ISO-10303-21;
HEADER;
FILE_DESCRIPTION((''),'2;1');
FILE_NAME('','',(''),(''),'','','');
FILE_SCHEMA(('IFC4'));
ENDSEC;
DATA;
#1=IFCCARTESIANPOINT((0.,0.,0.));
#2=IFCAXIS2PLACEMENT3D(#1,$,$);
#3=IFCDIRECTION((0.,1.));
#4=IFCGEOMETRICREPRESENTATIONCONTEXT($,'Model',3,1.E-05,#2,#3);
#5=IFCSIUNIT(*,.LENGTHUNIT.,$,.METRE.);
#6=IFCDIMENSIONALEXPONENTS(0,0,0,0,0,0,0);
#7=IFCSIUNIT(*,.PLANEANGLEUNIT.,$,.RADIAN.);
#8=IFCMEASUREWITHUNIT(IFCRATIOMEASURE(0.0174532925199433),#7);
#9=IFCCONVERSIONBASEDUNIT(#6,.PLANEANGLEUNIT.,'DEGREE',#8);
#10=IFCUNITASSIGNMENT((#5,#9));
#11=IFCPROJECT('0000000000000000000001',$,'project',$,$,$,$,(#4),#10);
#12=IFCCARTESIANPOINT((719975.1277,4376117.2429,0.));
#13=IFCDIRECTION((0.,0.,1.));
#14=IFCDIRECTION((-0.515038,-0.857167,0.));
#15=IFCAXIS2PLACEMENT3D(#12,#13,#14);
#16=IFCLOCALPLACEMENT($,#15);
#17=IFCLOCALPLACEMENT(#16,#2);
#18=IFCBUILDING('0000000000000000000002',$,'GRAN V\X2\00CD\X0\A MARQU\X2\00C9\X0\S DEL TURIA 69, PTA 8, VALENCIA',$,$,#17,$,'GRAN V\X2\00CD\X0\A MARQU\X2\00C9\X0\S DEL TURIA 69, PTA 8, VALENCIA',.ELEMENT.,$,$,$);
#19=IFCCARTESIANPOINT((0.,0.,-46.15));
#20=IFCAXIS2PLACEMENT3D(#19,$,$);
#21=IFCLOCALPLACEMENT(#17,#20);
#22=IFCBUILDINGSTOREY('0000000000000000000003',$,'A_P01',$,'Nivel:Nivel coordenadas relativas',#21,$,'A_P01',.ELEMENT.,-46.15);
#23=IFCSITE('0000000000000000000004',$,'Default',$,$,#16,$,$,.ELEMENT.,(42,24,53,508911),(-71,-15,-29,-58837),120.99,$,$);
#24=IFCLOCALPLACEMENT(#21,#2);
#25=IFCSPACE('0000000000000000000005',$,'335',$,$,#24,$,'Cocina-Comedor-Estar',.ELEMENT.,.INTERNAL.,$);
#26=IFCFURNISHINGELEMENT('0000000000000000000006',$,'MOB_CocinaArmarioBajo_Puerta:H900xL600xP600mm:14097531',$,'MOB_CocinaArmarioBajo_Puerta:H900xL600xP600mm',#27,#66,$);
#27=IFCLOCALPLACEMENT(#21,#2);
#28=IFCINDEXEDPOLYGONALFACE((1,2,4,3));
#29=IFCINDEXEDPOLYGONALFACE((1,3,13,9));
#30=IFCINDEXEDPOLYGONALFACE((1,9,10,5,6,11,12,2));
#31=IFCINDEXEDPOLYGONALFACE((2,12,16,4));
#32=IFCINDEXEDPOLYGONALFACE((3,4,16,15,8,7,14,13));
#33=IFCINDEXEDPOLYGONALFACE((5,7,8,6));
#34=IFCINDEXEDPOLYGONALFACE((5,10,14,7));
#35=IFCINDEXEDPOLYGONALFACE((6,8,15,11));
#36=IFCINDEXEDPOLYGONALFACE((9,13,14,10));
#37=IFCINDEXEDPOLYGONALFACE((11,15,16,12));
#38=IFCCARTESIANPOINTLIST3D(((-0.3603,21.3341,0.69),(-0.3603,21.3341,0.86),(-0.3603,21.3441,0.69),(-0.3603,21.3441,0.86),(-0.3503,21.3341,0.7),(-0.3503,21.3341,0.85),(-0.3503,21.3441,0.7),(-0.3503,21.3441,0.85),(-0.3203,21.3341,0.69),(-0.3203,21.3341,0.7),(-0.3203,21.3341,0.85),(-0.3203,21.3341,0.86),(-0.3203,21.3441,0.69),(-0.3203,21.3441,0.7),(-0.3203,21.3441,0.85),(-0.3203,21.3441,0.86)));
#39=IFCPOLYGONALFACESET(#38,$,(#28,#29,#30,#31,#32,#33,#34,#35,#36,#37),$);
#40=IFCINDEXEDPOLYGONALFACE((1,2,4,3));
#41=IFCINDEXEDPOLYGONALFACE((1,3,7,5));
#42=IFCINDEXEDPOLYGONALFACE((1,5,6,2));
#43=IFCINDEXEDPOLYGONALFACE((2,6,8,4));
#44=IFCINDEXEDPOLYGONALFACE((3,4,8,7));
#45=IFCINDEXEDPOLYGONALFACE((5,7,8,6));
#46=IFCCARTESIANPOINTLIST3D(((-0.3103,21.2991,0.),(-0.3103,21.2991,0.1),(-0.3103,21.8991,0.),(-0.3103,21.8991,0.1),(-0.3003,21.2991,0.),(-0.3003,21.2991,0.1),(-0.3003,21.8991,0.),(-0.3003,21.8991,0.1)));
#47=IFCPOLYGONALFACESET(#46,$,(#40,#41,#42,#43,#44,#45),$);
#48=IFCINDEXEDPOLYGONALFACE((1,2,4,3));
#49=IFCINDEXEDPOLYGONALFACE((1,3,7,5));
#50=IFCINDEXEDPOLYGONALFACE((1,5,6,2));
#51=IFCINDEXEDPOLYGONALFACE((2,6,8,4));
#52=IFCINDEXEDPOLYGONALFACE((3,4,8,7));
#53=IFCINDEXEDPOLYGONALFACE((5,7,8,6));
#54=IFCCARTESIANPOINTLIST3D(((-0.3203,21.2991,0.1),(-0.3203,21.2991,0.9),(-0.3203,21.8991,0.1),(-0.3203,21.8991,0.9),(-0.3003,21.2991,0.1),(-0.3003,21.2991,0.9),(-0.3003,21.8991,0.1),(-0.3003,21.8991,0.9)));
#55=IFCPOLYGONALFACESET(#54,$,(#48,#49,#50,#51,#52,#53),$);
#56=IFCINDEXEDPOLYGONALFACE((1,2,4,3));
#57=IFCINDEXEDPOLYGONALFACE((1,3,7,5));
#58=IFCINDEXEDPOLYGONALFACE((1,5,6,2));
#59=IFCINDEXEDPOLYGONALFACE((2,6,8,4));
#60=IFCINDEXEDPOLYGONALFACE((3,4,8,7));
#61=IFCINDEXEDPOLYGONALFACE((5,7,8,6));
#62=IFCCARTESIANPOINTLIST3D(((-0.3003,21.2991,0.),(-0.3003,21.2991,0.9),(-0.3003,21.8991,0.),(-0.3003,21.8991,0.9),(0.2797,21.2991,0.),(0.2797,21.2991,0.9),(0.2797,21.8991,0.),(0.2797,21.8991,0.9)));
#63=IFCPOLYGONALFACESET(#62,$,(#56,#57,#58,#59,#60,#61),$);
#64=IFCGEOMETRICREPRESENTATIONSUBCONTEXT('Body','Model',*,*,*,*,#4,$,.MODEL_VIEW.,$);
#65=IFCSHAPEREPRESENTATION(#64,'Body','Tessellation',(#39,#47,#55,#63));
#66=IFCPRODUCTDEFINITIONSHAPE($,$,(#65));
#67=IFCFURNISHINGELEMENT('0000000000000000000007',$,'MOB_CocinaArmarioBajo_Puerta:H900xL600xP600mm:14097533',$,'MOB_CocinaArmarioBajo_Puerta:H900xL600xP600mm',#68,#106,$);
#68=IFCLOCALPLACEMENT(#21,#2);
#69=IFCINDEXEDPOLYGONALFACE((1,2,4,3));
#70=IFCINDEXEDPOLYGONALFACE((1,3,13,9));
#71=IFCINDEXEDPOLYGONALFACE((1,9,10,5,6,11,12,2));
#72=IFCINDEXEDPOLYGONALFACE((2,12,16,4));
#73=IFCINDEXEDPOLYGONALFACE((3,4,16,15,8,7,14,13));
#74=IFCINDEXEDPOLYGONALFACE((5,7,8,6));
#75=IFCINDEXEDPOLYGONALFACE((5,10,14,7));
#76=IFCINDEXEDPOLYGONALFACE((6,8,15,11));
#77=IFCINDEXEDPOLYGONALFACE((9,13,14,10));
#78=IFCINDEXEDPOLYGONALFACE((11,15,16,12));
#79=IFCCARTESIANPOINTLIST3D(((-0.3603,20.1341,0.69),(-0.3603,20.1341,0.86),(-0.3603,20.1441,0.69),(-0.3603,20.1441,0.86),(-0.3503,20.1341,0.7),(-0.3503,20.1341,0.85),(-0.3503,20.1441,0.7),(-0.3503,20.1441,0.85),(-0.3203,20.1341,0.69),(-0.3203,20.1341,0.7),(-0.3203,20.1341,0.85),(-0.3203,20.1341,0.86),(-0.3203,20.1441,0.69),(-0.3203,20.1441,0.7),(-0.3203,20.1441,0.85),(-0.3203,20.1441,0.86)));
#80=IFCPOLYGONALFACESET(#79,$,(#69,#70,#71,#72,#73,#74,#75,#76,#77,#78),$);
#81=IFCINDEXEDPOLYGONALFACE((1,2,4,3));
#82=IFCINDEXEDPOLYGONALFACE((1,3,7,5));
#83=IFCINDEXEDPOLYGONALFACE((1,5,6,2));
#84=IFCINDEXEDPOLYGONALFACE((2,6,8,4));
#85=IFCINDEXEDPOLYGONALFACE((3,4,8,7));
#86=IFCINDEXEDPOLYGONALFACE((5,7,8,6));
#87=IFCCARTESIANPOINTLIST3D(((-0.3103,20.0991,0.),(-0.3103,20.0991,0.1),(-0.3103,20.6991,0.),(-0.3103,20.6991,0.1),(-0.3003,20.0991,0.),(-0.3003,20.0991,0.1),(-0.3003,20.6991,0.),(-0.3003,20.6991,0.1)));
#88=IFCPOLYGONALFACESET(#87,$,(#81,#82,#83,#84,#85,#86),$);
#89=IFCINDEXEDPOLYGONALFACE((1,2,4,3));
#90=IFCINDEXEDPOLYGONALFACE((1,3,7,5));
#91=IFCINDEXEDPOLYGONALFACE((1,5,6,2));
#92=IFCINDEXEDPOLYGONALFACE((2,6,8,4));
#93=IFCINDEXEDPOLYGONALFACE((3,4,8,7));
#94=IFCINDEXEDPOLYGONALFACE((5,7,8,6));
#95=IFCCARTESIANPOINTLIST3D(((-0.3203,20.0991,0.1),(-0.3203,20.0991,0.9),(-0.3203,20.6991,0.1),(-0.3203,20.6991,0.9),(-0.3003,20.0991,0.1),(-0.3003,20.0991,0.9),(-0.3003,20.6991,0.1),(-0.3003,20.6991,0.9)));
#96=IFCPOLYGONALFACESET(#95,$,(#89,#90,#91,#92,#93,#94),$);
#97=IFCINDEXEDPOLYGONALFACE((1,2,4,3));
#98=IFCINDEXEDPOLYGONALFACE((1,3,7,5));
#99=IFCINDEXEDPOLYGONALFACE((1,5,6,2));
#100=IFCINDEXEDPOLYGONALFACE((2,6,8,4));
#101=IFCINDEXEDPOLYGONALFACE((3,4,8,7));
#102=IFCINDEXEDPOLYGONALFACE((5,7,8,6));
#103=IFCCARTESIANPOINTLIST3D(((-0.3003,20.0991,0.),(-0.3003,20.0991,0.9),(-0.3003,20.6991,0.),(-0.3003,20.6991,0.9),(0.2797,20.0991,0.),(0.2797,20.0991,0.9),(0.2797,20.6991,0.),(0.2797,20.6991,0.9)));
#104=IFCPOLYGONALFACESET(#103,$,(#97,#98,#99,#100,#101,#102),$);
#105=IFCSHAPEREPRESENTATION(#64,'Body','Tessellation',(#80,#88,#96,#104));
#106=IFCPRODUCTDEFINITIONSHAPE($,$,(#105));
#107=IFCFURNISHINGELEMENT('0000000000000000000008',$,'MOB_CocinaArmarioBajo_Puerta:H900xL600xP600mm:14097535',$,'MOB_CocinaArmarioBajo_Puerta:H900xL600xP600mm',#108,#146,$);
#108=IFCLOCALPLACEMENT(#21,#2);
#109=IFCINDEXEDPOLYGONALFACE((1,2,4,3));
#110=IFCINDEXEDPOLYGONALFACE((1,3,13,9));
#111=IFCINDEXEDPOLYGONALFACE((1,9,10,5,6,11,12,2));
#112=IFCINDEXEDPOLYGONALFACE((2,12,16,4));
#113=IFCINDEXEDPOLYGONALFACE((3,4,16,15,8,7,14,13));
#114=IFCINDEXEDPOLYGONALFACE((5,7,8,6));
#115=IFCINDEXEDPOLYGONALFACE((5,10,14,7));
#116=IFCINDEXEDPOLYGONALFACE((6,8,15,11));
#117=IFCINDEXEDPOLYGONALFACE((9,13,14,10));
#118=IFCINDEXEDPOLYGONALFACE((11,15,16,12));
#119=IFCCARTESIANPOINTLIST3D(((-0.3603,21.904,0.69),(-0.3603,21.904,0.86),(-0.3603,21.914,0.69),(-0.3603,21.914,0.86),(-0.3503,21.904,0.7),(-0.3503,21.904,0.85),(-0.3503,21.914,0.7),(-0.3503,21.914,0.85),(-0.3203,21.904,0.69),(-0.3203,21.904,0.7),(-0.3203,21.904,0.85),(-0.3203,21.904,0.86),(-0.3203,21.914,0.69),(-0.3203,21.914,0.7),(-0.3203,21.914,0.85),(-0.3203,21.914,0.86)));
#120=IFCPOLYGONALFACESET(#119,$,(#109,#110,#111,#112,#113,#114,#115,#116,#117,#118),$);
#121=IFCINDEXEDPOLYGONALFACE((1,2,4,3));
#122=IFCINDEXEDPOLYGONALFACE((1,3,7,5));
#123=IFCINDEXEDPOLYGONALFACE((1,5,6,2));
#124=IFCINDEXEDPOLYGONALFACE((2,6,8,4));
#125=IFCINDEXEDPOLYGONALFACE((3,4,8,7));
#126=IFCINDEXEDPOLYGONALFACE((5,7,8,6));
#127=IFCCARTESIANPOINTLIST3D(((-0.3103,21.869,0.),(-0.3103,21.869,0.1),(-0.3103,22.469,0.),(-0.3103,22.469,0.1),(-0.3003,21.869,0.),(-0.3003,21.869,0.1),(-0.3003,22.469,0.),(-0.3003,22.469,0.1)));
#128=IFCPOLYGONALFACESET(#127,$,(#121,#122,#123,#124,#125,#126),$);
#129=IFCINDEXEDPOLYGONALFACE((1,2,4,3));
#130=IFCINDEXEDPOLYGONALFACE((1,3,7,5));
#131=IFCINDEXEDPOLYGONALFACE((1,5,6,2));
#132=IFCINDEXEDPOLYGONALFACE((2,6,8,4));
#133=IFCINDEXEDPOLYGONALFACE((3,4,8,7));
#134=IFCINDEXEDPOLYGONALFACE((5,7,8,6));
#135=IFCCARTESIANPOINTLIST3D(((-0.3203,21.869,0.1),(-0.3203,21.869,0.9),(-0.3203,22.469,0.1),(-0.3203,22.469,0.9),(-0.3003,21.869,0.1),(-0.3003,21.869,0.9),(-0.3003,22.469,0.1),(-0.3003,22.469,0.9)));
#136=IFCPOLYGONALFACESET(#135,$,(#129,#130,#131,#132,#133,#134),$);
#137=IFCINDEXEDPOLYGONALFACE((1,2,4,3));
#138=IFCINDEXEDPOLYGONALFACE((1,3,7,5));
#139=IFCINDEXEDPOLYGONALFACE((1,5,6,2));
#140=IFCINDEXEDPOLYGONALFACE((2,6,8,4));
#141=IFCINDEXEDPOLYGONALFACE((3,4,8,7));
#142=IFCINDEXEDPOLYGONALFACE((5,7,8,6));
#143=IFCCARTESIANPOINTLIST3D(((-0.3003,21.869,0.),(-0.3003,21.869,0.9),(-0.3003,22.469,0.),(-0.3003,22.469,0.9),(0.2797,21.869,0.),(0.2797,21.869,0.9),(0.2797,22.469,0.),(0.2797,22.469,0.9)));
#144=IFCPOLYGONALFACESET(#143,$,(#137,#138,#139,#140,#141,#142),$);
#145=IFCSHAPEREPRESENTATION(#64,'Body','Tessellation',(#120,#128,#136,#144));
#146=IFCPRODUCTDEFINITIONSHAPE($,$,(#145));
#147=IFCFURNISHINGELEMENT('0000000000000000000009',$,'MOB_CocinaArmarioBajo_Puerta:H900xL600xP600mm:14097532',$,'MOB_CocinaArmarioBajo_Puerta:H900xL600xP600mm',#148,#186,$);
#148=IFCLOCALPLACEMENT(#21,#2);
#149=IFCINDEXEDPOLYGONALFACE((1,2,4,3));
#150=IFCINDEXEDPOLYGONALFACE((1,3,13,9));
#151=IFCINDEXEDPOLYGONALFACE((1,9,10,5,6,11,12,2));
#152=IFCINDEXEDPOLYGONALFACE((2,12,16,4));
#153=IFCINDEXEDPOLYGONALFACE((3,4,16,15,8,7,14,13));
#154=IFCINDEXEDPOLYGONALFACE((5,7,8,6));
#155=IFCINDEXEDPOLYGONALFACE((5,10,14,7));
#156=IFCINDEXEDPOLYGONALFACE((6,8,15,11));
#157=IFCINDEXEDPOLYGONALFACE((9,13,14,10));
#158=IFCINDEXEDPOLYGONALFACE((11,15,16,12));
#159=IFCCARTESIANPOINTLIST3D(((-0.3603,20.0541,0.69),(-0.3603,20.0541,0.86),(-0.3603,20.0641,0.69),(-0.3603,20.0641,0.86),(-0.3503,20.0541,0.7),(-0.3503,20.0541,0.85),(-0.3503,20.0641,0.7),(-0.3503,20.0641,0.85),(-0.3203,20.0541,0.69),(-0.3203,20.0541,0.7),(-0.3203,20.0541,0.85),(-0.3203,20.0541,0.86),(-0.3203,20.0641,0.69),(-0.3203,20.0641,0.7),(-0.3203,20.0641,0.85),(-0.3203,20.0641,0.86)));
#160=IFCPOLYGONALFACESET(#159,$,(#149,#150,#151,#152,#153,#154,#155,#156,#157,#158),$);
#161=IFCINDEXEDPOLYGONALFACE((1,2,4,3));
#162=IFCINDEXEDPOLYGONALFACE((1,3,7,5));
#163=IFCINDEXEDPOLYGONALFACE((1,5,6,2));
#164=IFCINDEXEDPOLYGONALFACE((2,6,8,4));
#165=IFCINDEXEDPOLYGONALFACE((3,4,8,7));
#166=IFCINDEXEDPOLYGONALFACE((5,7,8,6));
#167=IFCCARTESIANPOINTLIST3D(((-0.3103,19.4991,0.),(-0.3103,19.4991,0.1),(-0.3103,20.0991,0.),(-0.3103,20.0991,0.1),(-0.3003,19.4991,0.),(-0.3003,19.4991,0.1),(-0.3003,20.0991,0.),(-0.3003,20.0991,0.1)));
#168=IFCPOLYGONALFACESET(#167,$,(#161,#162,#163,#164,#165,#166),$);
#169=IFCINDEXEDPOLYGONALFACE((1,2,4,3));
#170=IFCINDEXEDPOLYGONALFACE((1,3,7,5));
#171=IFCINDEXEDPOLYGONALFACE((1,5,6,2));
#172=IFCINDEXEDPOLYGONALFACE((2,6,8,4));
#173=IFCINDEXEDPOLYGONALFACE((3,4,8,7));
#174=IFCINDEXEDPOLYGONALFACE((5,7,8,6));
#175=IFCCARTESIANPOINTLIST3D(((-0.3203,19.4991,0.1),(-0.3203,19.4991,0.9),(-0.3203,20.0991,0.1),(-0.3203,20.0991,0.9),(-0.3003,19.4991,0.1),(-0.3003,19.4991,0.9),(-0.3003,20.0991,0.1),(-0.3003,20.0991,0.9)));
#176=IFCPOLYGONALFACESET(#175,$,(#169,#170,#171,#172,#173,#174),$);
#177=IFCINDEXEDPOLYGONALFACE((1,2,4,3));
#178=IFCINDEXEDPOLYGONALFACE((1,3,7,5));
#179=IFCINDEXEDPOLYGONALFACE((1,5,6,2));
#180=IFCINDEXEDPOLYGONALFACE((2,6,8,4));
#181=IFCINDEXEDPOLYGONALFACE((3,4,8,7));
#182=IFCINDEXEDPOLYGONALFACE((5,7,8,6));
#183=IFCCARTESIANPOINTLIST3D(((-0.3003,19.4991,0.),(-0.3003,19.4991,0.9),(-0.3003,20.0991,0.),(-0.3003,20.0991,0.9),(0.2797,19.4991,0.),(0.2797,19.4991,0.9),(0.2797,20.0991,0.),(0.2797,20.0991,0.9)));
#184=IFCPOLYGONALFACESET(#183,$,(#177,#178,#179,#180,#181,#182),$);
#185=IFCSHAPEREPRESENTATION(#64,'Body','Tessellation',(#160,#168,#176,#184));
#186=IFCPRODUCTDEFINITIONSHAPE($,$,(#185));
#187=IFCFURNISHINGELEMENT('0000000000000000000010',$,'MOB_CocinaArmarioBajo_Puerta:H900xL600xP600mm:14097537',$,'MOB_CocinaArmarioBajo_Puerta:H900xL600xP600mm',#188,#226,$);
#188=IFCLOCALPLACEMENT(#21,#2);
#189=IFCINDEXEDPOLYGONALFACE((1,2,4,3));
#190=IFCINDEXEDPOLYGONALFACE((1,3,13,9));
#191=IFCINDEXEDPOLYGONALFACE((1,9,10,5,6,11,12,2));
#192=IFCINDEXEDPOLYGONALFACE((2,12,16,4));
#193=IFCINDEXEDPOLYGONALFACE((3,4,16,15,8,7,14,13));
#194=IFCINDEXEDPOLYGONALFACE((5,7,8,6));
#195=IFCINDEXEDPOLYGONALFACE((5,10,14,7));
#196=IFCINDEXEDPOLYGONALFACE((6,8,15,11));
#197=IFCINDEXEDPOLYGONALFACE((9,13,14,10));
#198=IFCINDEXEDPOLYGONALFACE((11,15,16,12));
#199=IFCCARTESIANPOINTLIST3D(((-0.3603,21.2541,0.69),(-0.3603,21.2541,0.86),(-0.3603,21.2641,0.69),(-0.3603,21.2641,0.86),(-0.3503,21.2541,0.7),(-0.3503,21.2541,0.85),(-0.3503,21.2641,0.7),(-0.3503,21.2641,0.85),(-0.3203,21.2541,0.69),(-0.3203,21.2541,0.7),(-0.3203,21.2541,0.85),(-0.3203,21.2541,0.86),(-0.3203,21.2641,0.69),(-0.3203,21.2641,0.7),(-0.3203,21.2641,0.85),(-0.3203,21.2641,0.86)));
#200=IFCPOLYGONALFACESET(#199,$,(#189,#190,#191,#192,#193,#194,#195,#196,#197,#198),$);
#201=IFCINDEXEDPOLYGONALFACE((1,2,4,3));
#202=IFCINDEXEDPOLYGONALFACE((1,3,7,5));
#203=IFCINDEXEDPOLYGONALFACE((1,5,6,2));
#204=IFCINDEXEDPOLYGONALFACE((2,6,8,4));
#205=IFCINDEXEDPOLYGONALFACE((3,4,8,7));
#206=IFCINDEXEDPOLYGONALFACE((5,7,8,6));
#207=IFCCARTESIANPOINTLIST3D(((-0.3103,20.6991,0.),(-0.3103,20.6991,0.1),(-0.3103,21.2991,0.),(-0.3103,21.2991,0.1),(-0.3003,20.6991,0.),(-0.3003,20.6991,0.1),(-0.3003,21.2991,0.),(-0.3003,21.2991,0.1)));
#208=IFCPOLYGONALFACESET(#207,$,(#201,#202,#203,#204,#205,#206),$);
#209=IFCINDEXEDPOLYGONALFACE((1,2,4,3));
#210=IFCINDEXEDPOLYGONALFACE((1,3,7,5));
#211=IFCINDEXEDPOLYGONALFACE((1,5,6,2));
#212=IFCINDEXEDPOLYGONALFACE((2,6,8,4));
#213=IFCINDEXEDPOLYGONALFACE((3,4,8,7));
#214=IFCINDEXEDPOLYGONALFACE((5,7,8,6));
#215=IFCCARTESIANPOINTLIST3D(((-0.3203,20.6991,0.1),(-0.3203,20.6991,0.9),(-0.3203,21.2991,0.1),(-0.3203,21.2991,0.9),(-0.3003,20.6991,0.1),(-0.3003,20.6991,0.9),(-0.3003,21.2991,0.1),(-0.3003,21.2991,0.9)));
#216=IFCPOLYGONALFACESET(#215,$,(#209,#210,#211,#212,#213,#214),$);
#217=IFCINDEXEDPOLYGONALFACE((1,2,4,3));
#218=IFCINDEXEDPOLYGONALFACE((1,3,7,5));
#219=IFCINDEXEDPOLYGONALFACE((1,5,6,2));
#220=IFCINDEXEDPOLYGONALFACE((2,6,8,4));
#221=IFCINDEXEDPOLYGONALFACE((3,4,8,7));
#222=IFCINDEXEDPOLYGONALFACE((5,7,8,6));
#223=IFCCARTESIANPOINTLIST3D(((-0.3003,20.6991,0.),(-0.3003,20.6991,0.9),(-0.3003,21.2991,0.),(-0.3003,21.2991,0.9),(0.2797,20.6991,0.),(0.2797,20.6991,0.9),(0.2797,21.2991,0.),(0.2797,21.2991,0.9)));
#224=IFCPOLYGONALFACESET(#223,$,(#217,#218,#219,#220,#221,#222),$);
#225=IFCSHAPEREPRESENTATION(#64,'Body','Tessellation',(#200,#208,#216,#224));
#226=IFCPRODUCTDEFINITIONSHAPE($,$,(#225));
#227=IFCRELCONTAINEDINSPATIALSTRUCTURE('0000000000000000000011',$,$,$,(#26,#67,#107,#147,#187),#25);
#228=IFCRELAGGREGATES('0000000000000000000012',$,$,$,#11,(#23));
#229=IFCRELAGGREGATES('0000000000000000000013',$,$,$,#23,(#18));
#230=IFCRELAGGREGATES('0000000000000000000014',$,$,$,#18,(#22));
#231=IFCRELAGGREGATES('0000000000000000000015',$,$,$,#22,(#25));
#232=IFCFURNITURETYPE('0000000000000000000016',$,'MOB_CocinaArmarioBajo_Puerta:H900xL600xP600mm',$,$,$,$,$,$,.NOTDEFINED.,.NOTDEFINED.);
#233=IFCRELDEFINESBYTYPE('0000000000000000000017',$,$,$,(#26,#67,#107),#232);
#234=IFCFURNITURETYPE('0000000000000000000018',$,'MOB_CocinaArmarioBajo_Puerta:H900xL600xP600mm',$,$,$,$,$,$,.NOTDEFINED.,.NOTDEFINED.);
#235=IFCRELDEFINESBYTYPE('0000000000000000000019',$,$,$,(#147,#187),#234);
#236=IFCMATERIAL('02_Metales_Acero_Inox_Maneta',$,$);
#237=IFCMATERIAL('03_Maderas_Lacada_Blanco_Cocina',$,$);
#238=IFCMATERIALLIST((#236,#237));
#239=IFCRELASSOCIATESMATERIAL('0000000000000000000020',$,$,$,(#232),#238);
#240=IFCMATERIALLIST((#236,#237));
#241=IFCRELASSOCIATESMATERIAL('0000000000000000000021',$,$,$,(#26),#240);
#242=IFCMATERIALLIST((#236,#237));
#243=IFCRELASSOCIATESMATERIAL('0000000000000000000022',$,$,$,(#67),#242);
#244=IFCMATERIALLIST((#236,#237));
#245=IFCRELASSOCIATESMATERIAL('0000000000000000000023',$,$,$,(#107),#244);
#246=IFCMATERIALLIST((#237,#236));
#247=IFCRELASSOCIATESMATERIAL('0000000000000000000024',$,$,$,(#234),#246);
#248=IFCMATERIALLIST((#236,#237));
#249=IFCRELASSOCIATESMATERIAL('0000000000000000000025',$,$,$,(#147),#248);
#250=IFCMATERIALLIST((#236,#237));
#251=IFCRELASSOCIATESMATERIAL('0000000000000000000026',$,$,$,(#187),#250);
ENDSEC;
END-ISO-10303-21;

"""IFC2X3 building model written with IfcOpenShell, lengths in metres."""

from ifc_helpers import new_model, entity, si_unit, converted_unit, direction, frame, frame_2d, origin, origin_2d_with_axis, place, context, subcontext, project, spatial, polyline, rectangle, outline, extrude, source, transform, mapped, material, material_list, type_object, type_shapes, element, save


model = new_model("IFC2X3")

# Units and contexts
model_context = context("Model", 3, precision=1e-05, world=origin(), true_north=direction((0.0, 1.0)))
body_context = subcontext(model_context, "Body", "Model", "MODEL_VIEW")
ifc_project = project(units=[si_unit("LENGTHUNIT", "METRE"), converted_unit("PLANEANGLEUNIT", "DEGREE", entity("IfcRatioMeasure", 0.0174532925199433), si_unit("PLANEANGLEUNIT", "RADIAN"), dimensions=[0, 0, 0, 0, 0, 0, 0])], contexts=[model_context])

# Site, building, storey
site_placement = place(None, frame((719975.1277, 4376117.2429, 0.0), z_axis=(0.0, 0.0, 1.0), x_axis=(-0.515038, -0.857167, 0.0)))
site = spatial("IfcSite", under=ifc_project, at=site_placement, Name="Default", CompositionType="ELEMENT", RefLatitude=(42, 24, 53, 508911), RefLongitude=(-71, -15, -29, -58837), RefElevation=120.99)
building_placement = place(site_placement, origin())
building = spatial("IfcBuilding", under=site, at=building_placement, Name="GRAN VÍA MARQUÉS DEL TURIA 69, PTA 8, VALENCIA", LongName="GRAN VÍA MARQUÉS DEL TURIA 69, PTA 8, VALENCIA", CompositionType="ELEMENT")
storey_placement = place(building_placement, frame((0.0, 0.0, -46.15)))
storey = spatial("IfcBuildingStorey", under=building, at=storey_placement, Name="A_P01", ObjectType="Nivel:Nivel coordenadas relativas", LongName="A_P01", CompositionType="ELEMENT", Elevation=-46.15)

# Shared definitions
space_1_placement = place(storey_placement, origin())
space_1 = spatial("IfcSpace", under=storey, at=space_1_placement, Name="335", LongName="Cocina-Comedor-Estar", CompositionType="ELEMENT", InteriorOrExteriorSpace="INTERNAL")

# Furnishing elements
ifc_material_1 = material(Name="02_Metales_Acero_Inox_Maneta")
ifc_material_2 = material(Name="03_Maderas_Lacada_Blanco_Cocina")
ifc_material_list_1 = material_list([ifc_material_1, ifc_material_2])
ifc_material_list_2 = material_list([ifc_material_1, ifc_material_2])
furniture_type_1 = type_object("IfcFurnitureType", Name="MOB_CocinaArmarioBajo_Puerta:H900xL600xP600mm", material=ifc_material_list_2)
shared_shape_1 = source(origin(), body_context, "Body", "SweptSolid", [
    extrude(outline(polyline([(0.075, -0.0175), (0.085, -0.0175), (0.085, 0.0225), (-0.085, 0.0225), (-0.085, -0.0175), (-0.075, -0.0175), (-0.075, 0.0125), (0.075, 0.0125), (0.075, -0.0175)])), frame((-0.265, 0.6175, 0.775), z_axis=(1.0, 0.0, 0.0), x_axis=(0.0, 0.0, -1.0)), (0.0, 0.0, 1.0), 0.01),
    extrude(rectangle(XDim=0.6, YDim=0.01, at=origin_2d_with_axis()), frame((0.0, 0.585, 0.0), z_axis=(0.0, 0.0, 1.0), x_axis=(-1.0, 0.0, 0.0)), (0.0, 0.0, 1.0), 0.1),
    extrude(rectangle(XDim=0.02, YDim=0.6, at=frame_2d((0.0, 0.0), x_axis=(1.0, 0.0))), frame((0.0, 0.59, 0.1), z_axis=(0.0, 0.0, 1.0), x_axis=(0.0, -1.0, 0.0)), (0.0, 0.0, 1.0), 0.8),
    extrude(rectangle(XDim=0.6, YDim=0.58, at=origin_2d_with_axis()), frame((0.0, 0.29, 0.0)), (0.0, 0.0, 1.0), 0.9),
])
type_shapes(furniture_type_1, [shared_shape_1])
furnishing_1_placement = place(space_1_placement, frame((0.2797, 21.5991, 0.0), z_axis=(0.0, 0.0, 1.0), x_axis=(0.0, 1.0, 0.0)))
element("IfcFurnishingElement", 1, at=furnishing_1_placement, inside=space_1, type_object=furniture_type_1, material=ifc_material_list_1, Name="MOB_CocinaArmarioBajo_Puerta:H900xL600xP600mm:14097531", ObjectType="MOB_CocinaArmarioBajo_Puerta:H900xL600xP600mm", context=body_context, shape_type="MappedRepresentation", body=[
    mapped(shared_shape_1, transform((0.0, 0.0, 0.0), scale=1.0)),
])
ifc_material_list_3 = material_list([ifc_material_1, ifc_material_2])
furnishing_2_placement = place(space_1_placement, frame((0.2797, 20.3991, 0.0), z_axis=(0.0, 0.0, 1.0), x_axis=(0.0, 1.0, 0.0)))
element("IfcFurnishingElement", 2, at=furnishing_2_placement, inside=space_1, type_object=furniture_type_1, material=ifc_material_list_3, Name="MOB_CocinaArmarioBajo_Puerta:H900xL600xP600mm:14097533", ObjectType="MOB_CocinaArmarioBajo_Puerta:H900xL600xP600mm", context=body_context, shape_type="MappedRepresentation", body=[
    mapped(shared_shape_1, transform((0.0, 0.0, 0.0), scale=1.0)),
])
ifc_material_list_4 = material_list([ifc_material_1, ifc_material_2])
furnishing_3_placement = place(space_1_placement, frame((0.2797, 22.169, 0.0), z_axis=(0.0, 0.0, 1.0), x_axis=(0.0, 1.0, 0.0)))
element("IfcFurnishingElement", 3, at=furnishing_3_placement, inside=space_1, type_object=furniture_type_1, material=ifc_material_list_4, Name="MOB_CocinaArmarioBajo_Puerta:H900xL600xP600mm:14097535", ObjectType="MOB_CocinaArmarioBajo_Puerta:H900xL600xP600mm", context=body_context, shape_type="MappedRepresentation", body=[
    mapped(shared_shape_1, transform((0.0, 0.0, 0.0), scale=1.0)),
])
ifc_material_list_5 = material_list([ifc_material_1, ifc_material_2])
ifc_material_list_6 = material_list([ifc_material_2, ifc_material_1])
furniture_type_2 = type_object("IfcFurnitureType", Name="MOB_CocinaArmarioBajo_Puerta:H900xL600xP600mm", material=ifc_material_list_6)
shared_shape_2 = source(origin(), body_context, "Body", "SweptSolid", [
    extrude(outline(polyline([(-0.0175, -0.075), (-0.0175, -0.085), (0.0225, -0.085), (0.0225, 0.085), (-0.0175, 0.085), (-0.0175, 0.075), (0.0125, 0.075), (0.0125, -0.075), (-0.0175, -0.075)])), frame((-0.265, -0.6175, 0.775), z_axis=(-1.0, 0.0, 0.0), x_axis=(0.0, -1.0, 0.0)), (0.0, 0.0, -1.0), 0.01),
    extrude(rectangle(XDim=0.01, YDim=0.6, at=frame_2d((0.0, 0.0), x_axis=(1.0, 0.0))), frame((0.0, -0.585, 0.0), z_axis=(0.0, 0.0, 1.0), x_axis=(0.0, 1.0, 0.0)), (0.0, 0.0, 1.0), 0.1),
    extrude(rectangle(XDim=0.6, YDim=0.02, at=frame_2d((0.0, 0.0), x_axis=(1.0, 0.0))), frame((0.0, -0.59, 0.1)), (0.0, 0.0, 1.0), 0.8),
    extrude(rectangle(XDim=0.58, YDim=0.6, at=origin_2d_with_axis()), frame((0.0, -0.29, 0.0), z_axis=(0.0, 0.0, 1.0), x_axis=(0.0, -1.0, 0.0)), (0.0, 0.0, 1.0), 0.9),
])
type_shapes(furniture_type_2, [shared_shape_2])
furnishing_4_placement = place(space_1_placement, frame((0.2797, 19.7991, 0.0), z_axis=(0.0, 0.0, 1.0), x_axis=(0.0, -1.0, 0.0)))
element("IfcFurnishingElement", 4, at=furnishing_4_placement, inside=space_1, type_object=furniture_type_2, material=ifc_material_list_5, Name="MOB_CocinaArmarioBajo_Puerta:H900xL600xP600mm:14097532", ObjectType="MOB_CocinaArmarioBajo_Puerta:H900xL600xP600mm", context=body_context, shape_type="MappedRepresentation", body=[
    mapped(shared_shape_2, transform((0.0, 0.0, 0.0), scale=1.0)),
])
ifc_material_list_7 = material_list([ifc_material_1, ifc_material_2])
furnishing_5_placement = place(space_1_placement, frame((0.2797, 20.9991, 0.0), z_axis=(0.0, 0.0, 1.0), x_axis=(0.0, -1.0, 0.0)))
element("IfcFurnishingElement", 5, at=furnishing_5_placement, inside=space_1, type_object=furniture_type_2, material=ifc_material_list_7, Name="MOB_CocinaArmarioBajo_Puerta:H900xL600xP600mm:14097537", ObjectType="MOB_CocinaArmarioBajo_Puerta:H900xL600xP600mm", context=body_context, shape_type="MappedRepresentation", body=[
    mapped(shared_shape_2, transform((0.0, 0.0, 0.0), scale=1.0)),
])

save(model, "model.ifc")
